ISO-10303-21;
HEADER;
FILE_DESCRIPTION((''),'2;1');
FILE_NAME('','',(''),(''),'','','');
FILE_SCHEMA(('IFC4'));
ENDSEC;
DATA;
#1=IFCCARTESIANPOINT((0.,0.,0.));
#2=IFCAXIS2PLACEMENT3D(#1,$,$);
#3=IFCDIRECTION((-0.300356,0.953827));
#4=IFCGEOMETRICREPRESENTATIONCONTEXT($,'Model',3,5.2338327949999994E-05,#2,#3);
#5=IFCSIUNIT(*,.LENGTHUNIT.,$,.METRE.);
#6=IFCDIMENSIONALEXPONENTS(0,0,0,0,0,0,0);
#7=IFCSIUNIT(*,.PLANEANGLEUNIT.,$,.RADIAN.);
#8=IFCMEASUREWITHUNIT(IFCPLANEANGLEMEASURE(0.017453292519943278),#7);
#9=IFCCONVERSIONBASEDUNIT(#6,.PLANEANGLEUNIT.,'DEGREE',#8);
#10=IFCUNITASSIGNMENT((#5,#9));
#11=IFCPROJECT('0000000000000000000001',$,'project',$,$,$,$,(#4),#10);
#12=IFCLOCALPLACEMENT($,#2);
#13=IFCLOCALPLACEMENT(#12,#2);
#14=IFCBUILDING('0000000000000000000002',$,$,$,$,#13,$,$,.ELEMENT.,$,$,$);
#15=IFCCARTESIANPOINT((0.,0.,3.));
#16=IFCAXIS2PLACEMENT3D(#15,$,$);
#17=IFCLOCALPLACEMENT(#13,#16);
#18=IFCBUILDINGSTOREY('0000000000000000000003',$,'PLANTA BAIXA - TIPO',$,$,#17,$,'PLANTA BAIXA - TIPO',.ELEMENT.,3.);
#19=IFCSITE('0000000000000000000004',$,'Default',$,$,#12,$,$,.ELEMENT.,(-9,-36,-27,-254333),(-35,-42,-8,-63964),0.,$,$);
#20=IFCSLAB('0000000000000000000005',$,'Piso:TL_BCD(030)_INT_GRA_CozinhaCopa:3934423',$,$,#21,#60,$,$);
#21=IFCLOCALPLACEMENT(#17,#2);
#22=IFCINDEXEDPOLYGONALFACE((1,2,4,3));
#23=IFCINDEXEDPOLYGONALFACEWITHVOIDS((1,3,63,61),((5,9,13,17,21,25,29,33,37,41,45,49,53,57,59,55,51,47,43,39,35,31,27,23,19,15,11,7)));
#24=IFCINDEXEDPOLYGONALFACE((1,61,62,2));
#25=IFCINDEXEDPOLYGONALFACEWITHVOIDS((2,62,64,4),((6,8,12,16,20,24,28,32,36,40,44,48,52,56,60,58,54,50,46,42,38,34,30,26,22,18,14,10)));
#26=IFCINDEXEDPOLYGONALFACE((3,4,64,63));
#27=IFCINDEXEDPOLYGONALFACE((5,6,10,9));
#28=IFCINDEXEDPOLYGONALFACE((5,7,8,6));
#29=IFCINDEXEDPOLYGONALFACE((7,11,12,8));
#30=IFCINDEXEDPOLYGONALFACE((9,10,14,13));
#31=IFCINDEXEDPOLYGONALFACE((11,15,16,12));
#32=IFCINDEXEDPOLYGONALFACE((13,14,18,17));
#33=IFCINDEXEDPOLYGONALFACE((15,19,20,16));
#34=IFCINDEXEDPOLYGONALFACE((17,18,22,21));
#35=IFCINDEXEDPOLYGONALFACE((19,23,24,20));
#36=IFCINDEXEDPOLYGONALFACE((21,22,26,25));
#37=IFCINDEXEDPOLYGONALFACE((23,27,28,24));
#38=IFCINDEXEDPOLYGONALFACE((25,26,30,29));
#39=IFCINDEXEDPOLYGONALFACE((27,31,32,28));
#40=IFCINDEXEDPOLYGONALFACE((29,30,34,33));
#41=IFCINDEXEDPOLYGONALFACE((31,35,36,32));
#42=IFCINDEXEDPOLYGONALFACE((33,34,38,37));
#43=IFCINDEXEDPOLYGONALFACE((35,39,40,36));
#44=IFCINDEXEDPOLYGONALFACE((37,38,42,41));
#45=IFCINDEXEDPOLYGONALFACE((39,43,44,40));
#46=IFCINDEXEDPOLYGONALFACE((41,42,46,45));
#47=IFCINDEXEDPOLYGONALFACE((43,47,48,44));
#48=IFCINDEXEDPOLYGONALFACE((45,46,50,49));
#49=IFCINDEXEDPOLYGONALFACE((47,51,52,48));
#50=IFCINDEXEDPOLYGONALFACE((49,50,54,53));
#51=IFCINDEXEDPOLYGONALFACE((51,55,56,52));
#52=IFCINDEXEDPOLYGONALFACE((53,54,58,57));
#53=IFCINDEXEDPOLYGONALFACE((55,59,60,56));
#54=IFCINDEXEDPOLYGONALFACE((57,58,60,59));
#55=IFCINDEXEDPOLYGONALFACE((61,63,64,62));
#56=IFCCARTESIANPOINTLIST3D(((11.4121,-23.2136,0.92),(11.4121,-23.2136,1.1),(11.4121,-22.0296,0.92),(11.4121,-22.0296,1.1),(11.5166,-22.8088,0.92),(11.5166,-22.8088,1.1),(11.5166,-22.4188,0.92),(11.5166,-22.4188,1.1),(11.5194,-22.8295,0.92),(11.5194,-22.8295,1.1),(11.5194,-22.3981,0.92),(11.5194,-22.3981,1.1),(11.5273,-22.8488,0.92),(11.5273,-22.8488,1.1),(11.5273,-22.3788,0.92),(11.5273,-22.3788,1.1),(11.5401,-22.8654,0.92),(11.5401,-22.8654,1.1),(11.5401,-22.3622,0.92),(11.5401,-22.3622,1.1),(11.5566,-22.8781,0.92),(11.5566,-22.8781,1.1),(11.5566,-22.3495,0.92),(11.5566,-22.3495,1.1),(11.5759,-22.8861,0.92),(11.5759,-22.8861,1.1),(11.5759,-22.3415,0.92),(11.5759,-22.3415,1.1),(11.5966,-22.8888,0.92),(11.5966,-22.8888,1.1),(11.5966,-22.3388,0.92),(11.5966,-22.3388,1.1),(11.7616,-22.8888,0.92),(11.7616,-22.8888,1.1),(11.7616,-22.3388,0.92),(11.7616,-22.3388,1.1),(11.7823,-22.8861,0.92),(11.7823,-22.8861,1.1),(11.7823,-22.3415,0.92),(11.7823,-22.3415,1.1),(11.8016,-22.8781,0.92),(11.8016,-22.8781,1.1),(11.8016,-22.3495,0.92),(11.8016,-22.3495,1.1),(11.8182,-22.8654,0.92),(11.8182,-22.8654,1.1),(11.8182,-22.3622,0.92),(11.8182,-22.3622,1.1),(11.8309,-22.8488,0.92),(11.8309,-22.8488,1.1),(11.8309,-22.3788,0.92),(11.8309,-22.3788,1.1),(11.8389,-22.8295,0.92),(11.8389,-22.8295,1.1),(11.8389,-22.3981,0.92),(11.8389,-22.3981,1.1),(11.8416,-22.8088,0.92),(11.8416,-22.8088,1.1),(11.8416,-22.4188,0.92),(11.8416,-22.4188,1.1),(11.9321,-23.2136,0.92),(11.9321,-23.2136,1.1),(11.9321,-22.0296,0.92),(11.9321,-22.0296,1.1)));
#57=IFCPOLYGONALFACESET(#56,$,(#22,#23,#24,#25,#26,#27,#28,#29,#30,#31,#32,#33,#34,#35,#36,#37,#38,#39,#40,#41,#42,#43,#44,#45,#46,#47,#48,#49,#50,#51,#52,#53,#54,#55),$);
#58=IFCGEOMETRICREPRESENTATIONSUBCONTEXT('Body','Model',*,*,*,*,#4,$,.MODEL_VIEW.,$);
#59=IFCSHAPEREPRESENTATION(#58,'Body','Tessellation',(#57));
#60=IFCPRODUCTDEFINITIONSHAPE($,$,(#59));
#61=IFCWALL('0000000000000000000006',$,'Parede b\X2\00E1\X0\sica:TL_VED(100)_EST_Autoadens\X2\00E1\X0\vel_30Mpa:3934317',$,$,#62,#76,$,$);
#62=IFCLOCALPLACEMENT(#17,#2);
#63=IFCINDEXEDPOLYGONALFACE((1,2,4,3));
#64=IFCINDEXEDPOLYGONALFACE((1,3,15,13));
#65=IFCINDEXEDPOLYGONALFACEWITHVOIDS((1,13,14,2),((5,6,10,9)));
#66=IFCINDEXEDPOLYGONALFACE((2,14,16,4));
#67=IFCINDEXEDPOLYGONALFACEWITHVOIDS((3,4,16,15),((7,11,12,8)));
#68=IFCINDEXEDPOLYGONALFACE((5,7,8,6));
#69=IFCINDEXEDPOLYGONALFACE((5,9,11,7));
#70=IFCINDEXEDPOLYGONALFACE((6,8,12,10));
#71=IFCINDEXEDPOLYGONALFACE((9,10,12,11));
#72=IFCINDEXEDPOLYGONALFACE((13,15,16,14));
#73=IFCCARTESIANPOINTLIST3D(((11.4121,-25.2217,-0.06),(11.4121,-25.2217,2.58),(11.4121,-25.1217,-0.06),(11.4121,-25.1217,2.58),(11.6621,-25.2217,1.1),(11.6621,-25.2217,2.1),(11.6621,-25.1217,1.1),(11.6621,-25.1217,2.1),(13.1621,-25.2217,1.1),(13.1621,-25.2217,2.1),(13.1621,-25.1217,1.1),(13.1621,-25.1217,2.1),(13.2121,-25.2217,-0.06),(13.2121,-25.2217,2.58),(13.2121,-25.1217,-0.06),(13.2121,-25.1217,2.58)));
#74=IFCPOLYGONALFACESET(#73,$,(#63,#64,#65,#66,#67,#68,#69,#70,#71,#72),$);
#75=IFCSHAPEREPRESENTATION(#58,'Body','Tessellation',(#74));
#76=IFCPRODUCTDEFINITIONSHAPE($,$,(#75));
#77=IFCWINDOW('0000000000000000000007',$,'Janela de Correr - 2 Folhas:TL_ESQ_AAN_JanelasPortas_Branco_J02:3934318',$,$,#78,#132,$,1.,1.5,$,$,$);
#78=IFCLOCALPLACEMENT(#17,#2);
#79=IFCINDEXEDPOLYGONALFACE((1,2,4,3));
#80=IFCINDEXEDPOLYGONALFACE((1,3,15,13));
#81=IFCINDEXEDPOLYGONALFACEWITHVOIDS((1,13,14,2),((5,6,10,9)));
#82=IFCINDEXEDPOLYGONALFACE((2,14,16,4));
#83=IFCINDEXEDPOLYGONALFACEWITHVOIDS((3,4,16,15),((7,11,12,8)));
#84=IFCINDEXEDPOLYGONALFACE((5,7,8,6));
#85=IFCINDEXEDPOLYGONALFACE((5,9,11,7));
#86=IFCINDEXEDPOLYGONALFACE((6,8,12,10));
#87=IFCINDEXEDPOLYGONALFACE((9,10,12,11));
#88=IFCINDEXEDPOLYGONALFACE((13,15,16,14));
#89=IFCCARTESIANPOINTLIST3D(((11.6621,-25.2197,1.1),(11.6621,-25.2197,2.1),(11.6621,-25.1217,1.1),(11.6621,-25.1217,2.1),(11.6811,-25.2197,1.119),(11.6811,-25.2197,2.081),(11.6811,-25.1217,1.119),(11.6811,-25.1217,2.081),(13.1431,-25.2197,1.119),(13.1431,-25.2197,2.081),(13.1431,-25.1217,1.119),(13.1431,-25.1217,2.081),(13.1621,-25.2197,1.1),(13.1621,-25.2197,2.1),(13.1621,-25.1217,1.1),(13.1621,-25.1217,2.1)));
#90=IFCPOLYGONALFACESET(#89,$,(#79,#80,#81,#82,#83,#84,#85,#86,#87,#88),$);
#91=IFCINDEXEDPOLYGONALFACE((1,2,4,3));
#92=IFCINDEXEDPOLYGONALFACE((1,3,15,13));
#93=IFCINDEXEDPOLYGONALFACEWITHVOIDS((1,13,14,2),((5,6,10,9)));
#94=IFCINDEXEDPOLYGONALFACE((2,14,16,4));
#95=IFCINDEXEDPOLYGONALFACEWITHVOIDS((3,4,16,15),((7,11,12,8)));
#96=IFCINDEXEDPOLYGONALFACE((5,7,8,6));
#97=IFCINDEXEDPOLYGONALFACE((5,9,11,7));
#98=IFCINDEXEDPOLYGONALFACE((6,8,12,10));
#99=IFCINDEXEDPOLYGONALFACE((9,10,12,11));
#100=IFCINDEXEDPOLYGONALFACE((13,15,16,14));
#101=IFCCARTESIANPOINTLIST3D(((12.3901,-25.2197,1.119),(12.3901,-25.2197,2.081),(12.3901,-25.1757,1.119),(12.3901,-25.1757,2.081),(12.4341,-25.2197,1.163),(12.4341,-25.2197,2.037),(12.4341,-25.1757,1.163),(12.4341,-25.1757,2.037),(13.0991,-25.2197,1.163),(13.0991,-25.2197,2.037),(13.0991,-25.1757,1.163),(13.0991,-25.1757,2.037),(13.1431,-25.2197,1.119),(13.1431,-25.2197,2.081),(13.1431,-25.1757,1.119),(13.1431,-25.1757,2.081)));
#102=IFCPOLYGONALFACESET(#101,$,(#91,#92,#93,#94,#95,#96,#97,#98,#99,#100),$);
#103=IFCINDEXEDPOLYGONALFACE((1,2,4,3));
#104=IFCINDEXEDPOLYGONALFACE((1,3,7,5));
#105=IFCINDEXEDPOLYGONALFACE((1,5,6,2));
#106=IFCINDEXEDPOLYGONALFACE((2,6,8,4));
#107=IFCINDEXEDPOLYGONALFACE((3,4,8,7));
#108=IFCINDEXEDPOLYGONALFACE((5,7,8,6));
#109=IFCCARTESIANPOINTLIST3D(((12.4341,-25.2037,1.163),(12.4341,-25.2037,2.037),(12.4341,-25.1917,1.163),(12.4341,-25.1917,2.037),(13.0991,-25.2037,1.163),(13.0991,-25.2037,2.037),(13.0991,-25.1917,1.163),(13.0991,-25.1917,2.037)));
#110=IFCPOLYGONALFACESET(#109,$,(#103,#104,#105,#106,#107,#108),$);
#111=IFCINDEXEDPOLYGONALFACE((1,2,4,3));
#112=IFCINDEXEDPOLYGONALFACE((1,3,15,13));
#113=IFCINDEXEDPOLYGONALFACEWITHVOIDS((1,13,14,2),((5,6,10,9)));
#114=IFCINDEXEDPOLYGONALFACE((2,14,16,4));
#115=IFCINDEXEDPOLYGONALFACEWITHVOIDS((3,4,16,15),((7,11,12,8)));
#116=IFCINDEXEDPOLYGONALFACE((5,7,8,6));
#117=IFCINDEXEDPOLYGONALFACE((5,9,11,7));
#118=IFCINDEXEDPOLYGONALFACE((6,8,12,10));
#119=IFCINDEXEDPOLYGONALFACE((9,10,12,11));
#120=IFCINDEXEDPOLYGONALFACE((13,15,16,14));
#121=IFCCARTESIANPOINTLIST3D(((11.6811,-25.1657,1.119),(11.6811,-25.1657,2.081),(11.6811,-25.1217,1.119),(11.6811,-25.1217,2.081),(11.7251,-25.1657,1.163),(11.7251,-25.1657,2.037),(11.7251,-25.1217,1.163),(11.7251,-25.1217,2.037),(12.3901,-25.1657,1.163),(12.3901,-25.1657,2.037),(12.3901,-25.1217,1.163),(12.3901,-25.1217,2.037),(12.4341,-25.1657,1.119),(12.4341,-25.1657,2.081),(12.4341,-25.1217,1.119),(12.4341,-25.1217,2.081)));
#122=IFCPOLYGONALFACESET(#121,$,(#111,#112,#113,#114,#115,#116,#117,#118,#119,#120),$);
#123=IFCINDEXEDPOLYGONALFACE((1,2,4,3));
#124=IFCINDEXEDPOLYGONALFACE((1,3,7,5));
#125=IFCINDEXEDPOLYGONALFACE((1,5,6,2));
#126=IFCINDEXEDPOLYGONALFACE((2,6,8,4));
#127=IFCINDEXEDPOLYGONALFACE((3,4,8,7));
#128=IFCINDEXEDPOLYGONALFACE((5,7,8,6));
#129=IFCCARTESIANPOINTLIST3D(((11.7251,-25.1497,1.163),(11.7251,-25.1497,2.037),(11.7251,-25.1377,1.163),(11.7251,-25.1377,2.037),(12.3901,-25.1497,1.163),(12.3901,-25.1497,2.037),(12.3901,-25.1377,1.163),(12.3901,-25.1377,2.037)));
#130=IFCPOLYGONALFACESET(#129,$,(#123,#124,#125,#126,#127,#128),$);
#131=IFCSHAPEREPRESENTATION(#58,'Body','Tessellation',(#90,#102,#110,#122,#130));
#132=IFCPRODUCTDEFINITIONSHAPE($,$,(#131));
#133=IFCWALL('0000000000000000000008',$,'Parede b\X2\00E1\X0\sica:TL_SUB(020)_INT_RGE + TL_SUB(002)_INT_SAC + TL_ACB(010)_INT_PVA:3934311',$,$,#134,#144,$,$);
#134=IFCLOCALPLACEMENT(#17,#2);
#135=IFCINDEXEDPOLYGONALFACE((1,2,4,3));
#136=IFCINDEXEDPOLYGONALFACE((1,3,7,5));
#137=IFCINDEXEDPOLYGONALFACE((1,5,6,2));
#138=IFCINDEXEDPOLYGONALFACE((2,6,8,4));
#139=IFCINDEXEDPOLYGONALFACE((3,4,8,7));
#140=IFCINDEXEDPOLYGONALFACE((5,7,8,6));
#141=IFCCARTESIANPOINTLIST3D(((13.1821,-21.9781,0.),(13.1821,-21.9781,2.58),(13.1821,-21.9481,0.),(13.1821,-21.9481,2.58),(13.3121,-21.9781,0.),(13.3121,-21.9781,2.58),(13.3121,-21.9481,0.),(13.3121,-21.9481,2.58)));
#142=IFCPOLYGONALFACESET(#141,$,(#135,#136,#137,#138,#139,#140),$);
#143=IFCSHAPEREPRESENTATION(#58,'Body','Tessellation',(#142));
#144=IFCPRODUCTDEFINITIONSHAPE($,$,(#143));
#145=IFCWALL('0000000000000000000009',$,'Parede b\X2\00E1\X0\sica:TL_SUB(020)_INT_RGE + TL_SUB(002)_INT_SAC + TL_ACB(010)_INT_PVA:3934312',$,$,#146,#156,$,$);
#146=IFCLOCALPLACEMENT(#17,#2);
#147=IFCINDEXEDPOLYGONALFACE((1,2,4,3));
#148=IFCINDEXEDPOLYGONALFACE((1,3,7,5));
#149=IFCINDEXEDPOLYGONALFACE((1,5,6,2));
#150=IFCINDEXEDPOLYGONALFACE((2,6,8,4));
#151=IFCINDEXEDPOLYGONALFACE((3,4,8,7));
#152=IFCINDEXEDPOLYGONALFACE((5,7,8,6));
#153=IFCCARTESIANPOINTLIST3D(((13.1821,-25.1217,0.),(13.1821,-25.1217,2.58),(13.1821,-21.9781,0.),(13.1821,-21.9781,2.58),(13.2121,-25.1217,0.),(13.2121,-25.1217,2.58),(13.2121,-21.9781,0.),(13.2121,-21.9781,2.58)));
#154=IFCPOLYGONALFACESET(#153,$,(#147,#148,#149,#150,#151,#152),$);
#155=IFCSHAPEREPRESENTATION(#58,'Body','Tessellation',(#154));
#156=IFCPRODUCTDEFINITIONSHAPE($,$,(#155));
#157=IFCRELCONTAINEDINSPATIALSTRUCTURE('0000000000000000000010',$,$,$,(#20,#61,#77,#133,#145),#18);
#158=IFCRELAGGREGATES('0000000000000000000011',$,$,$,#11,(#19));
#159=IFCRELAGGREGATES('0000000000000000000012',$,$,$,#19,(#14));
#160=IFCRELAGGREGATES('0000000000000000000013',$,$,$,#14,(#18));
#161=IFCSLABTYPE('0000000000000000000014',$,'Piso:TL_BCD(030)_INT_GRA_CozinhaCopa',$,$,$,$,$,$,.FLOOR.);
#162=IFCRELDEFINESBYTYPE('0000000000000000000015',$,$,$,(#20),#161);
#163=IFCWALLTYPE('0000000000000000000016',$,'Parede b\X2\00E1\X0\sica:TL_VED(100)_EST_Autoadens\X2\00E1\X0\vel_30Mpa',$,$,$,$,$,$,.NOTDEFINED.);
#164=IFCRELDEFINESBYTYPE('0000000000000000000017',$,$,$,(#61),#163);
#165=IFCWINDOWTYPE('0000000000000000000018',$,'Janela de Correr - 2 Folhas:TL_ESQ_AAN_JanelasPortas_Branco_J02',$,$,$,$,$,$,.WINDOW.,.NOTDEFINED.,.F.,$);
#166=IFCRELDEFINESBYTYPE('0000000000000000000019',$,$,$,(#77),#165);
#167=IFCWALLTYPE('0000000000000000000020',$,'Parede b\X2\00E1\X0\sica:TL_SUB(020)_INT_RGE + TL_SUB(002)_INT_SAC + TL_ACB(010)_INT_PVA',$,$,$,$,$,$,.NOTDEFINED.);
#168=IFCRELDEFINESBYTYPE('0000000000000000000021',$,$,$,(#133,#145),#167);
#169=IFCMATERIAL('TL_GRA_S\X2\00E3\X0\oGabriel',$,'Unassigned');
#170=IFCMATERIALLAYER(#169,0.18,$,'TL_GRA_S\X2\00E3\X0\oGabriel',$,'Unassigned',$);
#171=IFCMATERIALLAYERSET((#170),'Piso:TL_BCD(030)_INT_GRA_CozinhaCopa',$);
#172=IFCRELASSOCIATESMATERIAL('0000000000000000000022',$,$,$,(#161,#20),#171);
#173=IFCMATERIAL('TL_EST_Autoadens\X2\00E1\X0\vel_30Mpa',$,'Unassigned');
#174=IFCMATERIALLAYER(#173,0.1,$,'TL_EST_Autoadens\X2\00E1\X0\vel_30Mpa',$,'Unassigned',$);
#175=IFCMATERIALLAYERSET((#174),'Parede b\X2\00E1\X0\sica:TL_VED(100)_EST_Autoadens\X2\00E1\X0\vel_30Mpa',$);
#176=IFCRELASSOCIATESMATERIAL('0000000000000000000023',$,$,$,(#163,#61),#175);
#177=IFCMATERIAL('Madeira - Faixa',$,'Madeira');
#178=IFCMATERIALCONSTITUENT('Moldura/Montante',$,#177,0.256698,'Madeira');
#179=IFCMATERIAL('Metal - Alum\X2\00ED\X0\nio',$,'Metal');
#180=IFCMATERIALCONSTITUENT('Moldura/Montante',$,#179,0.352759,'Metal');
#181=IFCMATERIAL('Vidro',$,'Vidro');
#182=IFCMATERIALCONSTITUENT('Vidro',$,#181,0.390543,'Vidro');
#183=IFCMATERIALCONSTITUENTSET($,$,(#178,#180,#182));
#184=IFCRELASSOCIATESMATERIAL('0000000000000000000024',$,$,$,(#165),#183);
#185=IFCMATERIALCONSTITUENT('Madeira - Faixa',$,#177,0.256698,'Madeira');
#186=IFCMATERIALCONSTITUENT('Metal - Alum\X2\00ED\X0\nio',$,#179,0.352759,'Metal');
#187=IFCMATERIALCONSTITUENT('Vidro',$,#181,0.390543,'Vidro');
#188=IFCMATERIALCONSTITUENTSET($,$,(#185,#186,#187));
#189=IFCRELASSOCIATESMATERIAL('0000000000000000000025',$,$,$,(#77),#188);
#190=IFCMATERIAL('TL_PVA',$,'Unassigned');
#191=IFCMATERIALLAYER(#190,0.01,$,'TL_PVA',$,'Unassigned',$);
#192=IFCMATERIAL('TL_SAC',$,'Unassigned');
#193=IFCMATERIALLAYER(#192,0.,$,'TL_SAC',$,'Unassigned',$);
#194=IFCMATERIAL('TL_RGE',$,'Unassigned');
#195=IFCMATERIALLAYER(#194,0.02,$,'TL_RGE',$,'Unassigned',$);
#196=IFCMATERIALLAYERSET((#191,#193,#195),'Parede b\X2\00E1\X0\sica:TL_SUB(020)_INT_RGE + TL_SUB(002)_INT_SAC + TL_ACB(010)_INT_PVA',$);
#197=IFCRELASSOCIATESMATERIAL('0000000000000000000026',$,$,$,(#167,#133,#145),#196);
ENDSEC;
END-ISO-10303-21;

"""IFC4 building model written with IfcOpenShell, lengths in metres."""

from ifc_helpers import new_model, entity, si_unit, converted_unit, direction, frame, frame_2d, origin, origin_2d_with_axis, place, context, subcontext, project, spatial, polyline, circle_curve, parameter, trimmed, segment, composite_curve, rectangle, outline, extrude, source, transform, mapped, material, layer, layer_set, layer_usage, constituent, constituent_set, type_object, type_shapes, element, fill, save


model = new_model("IFC4")

# Units and contexts
model_context = context("Model", 3, precision=5.2338327949999994e-05, world=origin(), true_north=direction((-0.300356, 0.953827)))
body_context = subcontext(model_context, "Body", "Model", "MODEL_VIEW")
ifc_project = project(units=[si_unit("LENGTHUNIT", "METRE"), converted_unit("PLANEANGLEUNIT", "DEGREE", entity("IfcPlaneAngleMeasure", 0.017453292519943278), si_unit("PLANEANGLEUNIT", "RADIAN"), dimensions=[0, 0, 0, 0, 0, 0, 0])], contexts=[model_context])

# Site, building, storey
site_placement = place(None, origin())
site = spatial("IfcSite", under=ifc_project, at=site_placement, Name="Default", CompositionType="ELEMENT", RefLatitude=(-9, -36, -27, -254333), RefLongitude=(-35, -42, -8, -63964), RefElevation=0.0)
building_placement = place(site_placement, origin())
building = spatial("IfcBuilding", under=site, at=building_placement, CompositionType="ELEMENT")
storey_placement = place(building_placement, frame((0.0, 0.0, 3.0)))
storey = spatial("IfcBuildingStorey", under=building, at=storey_placement, Name="PLANTA BAIXA - TIPO", LongName="PLANTA BAIXA - TIPO", CompositionType="ELEMENT", Elevation=3.0)

# Slab, opening
ifc_material_1 = material(Name="TL_GRA_SãoGabriel", Category="Unassigned")
ifc_layer_1 = layer(ifc_material_1, 0.18, Name="TL_GRA_SãoGabriel", Category="Unassigned")
ifc_layer_set_1 = layer_set([ifc_layer_1], Name="Piso:TL_BCD(030)_INT_GRA_CozinhaCopa")
ifc_layer_usage_1 = layer_usage(ifc_layer_set_1, "AXIS3", "POSITIVE", 0.0)
slab_type_1 = type_object("IfcSlabType", Name="Piso:TL_BCD(030)_INT_GRA_CozinhaCopa", PredefinedType="FLOOR", material=ifc_layer_set_1)
slab_1_placement = place(storey_placement, frame((11.4121, -23.2136, 0.92)))
slab_1 = element("IfcSlab", 1, at=slab_1_placement, inside=storey, type_object=slab_type_1, material=ifc_layer_usage_1, Name="Piso:TL_BCD(030)_INT_GRA_CozinhaCopa:3934423", context=body_context, shape_type="SweptSolid", body=[
    extrude(rectangle(XDim=1.184, YDim=0.52, at=frame_2d((0.0, 0.0), x_axis=(0.0, 1.0))), frame((0.26, 0.592, 0.18), z_axis=(0.0, 0.0, -1.0), x_axis=(-1.0, 0.0, 0.0)), (0.0, 0.0, 1.0), 0.18),
])
opening_1_placement = place(slab_1_placement, frame((-11.4121, 23.2136, 0.18)))
element("IfcOpeningElement", 2, at=opening_1_placement, cuts=slab_1, PredefinedType="OPENING", context=body_context, shape_type="SweptSolid", body=[
    extrude(outline(composite_curve([segment(polyline([(-0.195, -0.1625), (0.195, -0.1625)]), True, "CONTINUOUS"), segment(trimmed(circle_curve(frame_2d((0.195, -0.0825), x_axis=(-1.0, 0.0)), 0.08), [parameter(90.0)], [parameter(180.0)], True, "PARAMETER"), True, "CONTINUOUS"), segment(polyline([(0.275, -0.0825), (0.275, 0.0825)]), True, "CONTINUOUS"), segment(trimmed(circle_curve(frame_2d((0.195, 0.0825), x_axis=(-1.0, 0.0)), 0.08), [parameter(180.0)], [parameter(270.0)], True, "PARAMETER"), True, "CONTINUOUS"), segment(polyline([(0.195, 0.1625), (-0.195, 0.1625)]), True, "CONTINUOUS"), segment(trimmed(circle_curve(frame_2d((-0.195, 0.0825), x_axis=(-1.0, 0.0)), 0.08), [parameter(270.0)], [parameter(360.0)], True, "PARAMETER"), True, "CONTINUOUS"), segment(polyline([(-0.275, 0.0825), (-0.275, -0.0825)]), True, "CONTINUOUS"), segment(trimmed(circle_curve(frame_2d((-0.195, -0.0825), x_axis=(-1.0, 0.0)), 0.08), [parameter(360.0)], [parameter(90.0)], True, "PARAMETER"), True, "CONTINUOUS")], self_intersect=False)), frame((11.6791, -22.6138, -0.21), z_axis=(0.0, 0.0, 1.0), x_axis=(0.0, -1.0, 0.0)), (0.0, 0.0, 1.0), 0.21),
])

# Wall, opening, window
ifc_material_2 = material(Name="TL_EST_Autoadensável_30Mpa", Category="Unassigned")
ifc_layer_2 = layer(ifc_material_2, 0.1, Name="TL_EST_Autoadensável_30Mpa", Category="Unassigned")
ifc_layer_set_2 = layer_set([ifc_layer_2], Name="Parede básica:TL_VED(100)_EST_Autoadensável_30Mpa")
ifc_layer_usage_2 = layer_usage(ifc_layer_set_2, "AXIS2", "NEGATIVE", 0.05)
wall_type_1 = type_object("IfcWallType", Name="Parede básica:TL_VED(100)_EST_Autoadensável_30Mpa", PredefinedType="NOTDEFINED", material=ifc_layer_set_2)
wall_1_placement = place(storey_placement, frame((13.2121, -25.1717, -0.06), z_axis=(0.0, 0.0, 1.0), x_axis=(-1.0, 0.0, 0.0)))
wall_1 = element("IfcWall", 3, at=wall_1_placement, inside=storey, type_object=wall_type_1, material=ifc_layer_usage_2, Name="Parede básica:TL_VED(100)_EST_Autoadensável_30Mpa:3934317", context=body_context, shape_type="SweptSolid", body=[
    extrude(rectangle(XDim=1.8, YDim=0.1, at=frame_2d((0.9, 0.0), x_axis=(-1.0, 0.0))), origin(), (0.0, 0.0, 1.0), 2.64),
])
opening_2_placement = place(wall_1_placement, frame((0.05, -0.05, 1.16)))
opening_2 = element("IfcOpeningElement", 4, at=opening_2_placement, cuts=wall_1, PredefinedType="OPENING", context=body_context, shape_type="SweptSolid", body=[
    extrude(rectangle(XDim=1.0, YDim=1.5, at=frame_2d((0.5, 0.75), x_axis=(-1.0, 0.0))), frame((0.0, 0.0, 0.0), z_axis=(0.0, 1.0, 0.0), x_axis=(0.0, 0.0, 1.0)), (0.0, 0.0, 1.0), 0.1),
])
ifc_material_3 = material(Name="Madeira - Faixa", Category="Madeira")
ifc_constituent_1 = constituent(ifc_material_3, Name="Madeira - Faixa", Category="Madeira", fraction=0.256698)
ifc_material_4 = material(Name="Metal - Alumínio", Category="Metal")
ifc_constituent_2 = constituent(ifc_material_4, Name="Metal - Alumínio", Category="Metal", fraction=0.352759)
ifc_material_5 = material(Name="Vidro", Category="Vidro")
ifc_constituent_3 = constituent(ifc_material_5, Name="Vidro", Category="Vidro", fraction=0.390543)
ifc_constituent_set_1 = constituent_set(constituents=[ifc_constituent_1, ifc_constituent_2, ifc_constituent_3])
ifc_constituent_4 = constituent(ifc_material_3, Name="Moldura/Montante", Category="Madeira", fraction=0.256698)
ifc_constituent_5 = constituent(ifc_material_4, Name="Moldura/Montante", Category="Metal", fraction=0.352759)
ifc_constituent_6 = constituent(ifc_material_5, Name="Vidro", Category="Vidro", fraction=0.390543)
ifc_constituent_set_2 = constituent_set(constituents=[ifc_constituent_4, ifc_constituent_5, ifc_constituent_6])
window_type = type_object("IfcWindowType", Name="Janela de Correr - 2 Folhas:TL_ESQ_AAN_JanelasPortas_Branco_J02", ParameterTakesPrecedence=False, PartitioningType="NOTDEFINED", PredefinedType="WINDOW", material=ifc_constituent_set_2)
shared_shape_1 = source(origin(), body_context, "Body", "SweptSolid", [
    extrude(outline(polyline([(-0.75, -0.5), (0.75, -0.5), (0.75, 0.5), (-0.75, 0.5), (-0.75, -0.5)]), holes=[polyline([(-0.731, -0.481), (-0.731, 0.481), (0.731, 0.481), (0.731, -0.481), (-0.731, -0.481)])]), frame((0.75, 0.124, 0.5), z_axis=(0.0, -1.0, 0.0), x_axis=(-1.0, 0.0, 0.0)), (0.0, 0.0, 1.0), 0.098),
    extrude(outline(polyline([(-0.3765, -0.481), (0.3765, -0.481), (0.3765, 0.481), (-0.3765, 0.481), (-0.3765, -0.481)]), holes=[polyline([(-0.3325, -0.437), (-0.3325, 0.437), (0.3325, 0.437), (0.3325, -0.437), (-0.3325, -0.437)])]), frame((0.3955, 0.124, 0.5), z_axis=(0.0, -1.0, 0.0), x_axis=(-1.0, 0.0, 0.0)), (0.0, 0.0, 1.0), 0.044),
    extrude(rectangle(XDim=0.665, YDim=0.012, at=origin_2d_with_axis()), frame((0.3955, 0.102, 0.063), z_axis=(0.0, 0.0, 1.0), x_axis=(-1.0, 0.0, 0.0)), (0.0, 0.0, 1.0), 0.874),
    extrude(outline(polyline([(-0.481, -0.3765), (0.481, -0.3765), (0.481, 0.3765), (-0.481, 0.3765), (-0.481, -0.3765)]), holes=[polyline([(-0.437, -0.3325), (-0.437, 0.3325), (0.437, 0.3325), (0.437, -0.3325), (-0.437, -0.3325)])]), frame((1.1045, 0.07, 0.5), z_axis=(0.0, -1.0, 0.0), x_axis=(0.0, 0.0, -1.0)), (0.0, 0.0, 1.0), 0.044),
    extrude(rectangle(XDim=0.665, YDim=0.012, at=origin_2d_with_axis()), frame((1.1045, 0.048, 0.063), z_axis=(0.0, 0.0, 1.0), x_axis=(-1.0, 0.0, 0.0)), (0.0, 0.0, 1.0), 0.874),
])
type_shapes(window_type, [shared_shape_1])
window_placement = place(opening_2_placement, frame((0.0, -0.026, 0.0)))
window = element("IfcWindow", 5, at=window_placement, inside=storey, type_object=window_type, material=ifc_constituent_set_1, Name="Janela de Correr - 2 Folhas:TL_ESQ_AAN_JanelasPortas_Branco_J02:3934318", OverallHeight=1.0, OverallWidth=1.5, context=body_context, shape_type="MappedRepresentation", body=[
    mapped(shared_shape_1, transform((0.0, 0.0, 0.0), scale=1.0)),
])
fill(opening_2, window)

# Walls
ifc_material_6 = material(Name="TL_PVA", Category="Unassigned")
ifc_layer_3 = layer(ifc_material_6, 0.01, Name="TL_PVA", Category="Unassigned")
ifc_material_7 = material(Name="TL_SAC", Category="Unassigned")
ifc_layer_4 = layer(ifc_material_7, 0.0, Name="TL_SAC", Category="Unassigned")
ifc_material_8 = material(Name="TL_RGE", Category="Unassigned")
ifc_layer_5 = layer(ifc_material_8, 0.02, Name="TL_RGE", Category="Unassigned")
ifc_layer_set_3 = layer_set([ifc_layer_3, ifc_layer_4, ifc_layer_5], Name="Parede básica:TL_SUB(020)_INT_RGE + TL_SUB(002)_INT_SAC + TL_ACB(010)_INT_PVA")
ifc_layer_usage_3 = layer_usage(ifc_layer_set_3, "AXIS2", "NEGATIVE", 0.015)
wall_type_2 = type_object("IfcWallType", Name="Parede básica:TL_SUB(020)_INT_RGE + TL_SUB(002)_INT_SAC + TL_ACB(010)_INT_PVA", PredefinedType="NOTDEFINED", material=ifc_layer_set_3)
wall_2_placement = place(storey_placement, frame((13.1821, -21.9631, 0.0)))
element("IfcWall", 6, at=wall_2_placement, inside=storey, type_object=wall_type_2, material=ifc_layer_usage_3, Name="Parede básica:TL_SUB(020)_INT_RGE + TL_SUB(002)_INT_SAC + TL_ACB(010)_INT_PVA:3934311", context=body_context, shape_type="SweptSolid", body=[
    extrude(rectangle(XDim=0.13, YDim=0.03, at=frame_2d((0.065, 0.0), x_axis=(-1.0, 0.0))), origin(), (0.0, 0.0, 1.0), 2.58),
])
ifc_layer_usage_4 = layer_usage(ifc_layer_set_3, "AXIS2", "NEGATIVE", 0.015)
wall_3_placement = place(storey_placement, frame((13.1971, -25.1217, 0.0), z_axis=(0.0, 0.0, 1.0), x_axis=(0.0, 1.0, 0.0)))
element("IfcWall", 7, at=wall_3_placement, inside=storey, type_object=wall_type_2, material=ifc_layer_usage_4, Name="Parede básica:TL_SUB(020)_INT_RGE + TL_SUB(002)_INT_SAC + TL_ACB(010)_INT_PVA:3934312", context=body_context, shape_type="SweptSolid", body=[
    extrude(rectangle(XDim=3.1437, YDim=0.03, at=frame_2d((1.5718, 0.0), x_axis=(-1.0, 0.0))), origin(), (0.0, 0.0, 1.0), 2.58),
])

save(model, "model.ifc")
